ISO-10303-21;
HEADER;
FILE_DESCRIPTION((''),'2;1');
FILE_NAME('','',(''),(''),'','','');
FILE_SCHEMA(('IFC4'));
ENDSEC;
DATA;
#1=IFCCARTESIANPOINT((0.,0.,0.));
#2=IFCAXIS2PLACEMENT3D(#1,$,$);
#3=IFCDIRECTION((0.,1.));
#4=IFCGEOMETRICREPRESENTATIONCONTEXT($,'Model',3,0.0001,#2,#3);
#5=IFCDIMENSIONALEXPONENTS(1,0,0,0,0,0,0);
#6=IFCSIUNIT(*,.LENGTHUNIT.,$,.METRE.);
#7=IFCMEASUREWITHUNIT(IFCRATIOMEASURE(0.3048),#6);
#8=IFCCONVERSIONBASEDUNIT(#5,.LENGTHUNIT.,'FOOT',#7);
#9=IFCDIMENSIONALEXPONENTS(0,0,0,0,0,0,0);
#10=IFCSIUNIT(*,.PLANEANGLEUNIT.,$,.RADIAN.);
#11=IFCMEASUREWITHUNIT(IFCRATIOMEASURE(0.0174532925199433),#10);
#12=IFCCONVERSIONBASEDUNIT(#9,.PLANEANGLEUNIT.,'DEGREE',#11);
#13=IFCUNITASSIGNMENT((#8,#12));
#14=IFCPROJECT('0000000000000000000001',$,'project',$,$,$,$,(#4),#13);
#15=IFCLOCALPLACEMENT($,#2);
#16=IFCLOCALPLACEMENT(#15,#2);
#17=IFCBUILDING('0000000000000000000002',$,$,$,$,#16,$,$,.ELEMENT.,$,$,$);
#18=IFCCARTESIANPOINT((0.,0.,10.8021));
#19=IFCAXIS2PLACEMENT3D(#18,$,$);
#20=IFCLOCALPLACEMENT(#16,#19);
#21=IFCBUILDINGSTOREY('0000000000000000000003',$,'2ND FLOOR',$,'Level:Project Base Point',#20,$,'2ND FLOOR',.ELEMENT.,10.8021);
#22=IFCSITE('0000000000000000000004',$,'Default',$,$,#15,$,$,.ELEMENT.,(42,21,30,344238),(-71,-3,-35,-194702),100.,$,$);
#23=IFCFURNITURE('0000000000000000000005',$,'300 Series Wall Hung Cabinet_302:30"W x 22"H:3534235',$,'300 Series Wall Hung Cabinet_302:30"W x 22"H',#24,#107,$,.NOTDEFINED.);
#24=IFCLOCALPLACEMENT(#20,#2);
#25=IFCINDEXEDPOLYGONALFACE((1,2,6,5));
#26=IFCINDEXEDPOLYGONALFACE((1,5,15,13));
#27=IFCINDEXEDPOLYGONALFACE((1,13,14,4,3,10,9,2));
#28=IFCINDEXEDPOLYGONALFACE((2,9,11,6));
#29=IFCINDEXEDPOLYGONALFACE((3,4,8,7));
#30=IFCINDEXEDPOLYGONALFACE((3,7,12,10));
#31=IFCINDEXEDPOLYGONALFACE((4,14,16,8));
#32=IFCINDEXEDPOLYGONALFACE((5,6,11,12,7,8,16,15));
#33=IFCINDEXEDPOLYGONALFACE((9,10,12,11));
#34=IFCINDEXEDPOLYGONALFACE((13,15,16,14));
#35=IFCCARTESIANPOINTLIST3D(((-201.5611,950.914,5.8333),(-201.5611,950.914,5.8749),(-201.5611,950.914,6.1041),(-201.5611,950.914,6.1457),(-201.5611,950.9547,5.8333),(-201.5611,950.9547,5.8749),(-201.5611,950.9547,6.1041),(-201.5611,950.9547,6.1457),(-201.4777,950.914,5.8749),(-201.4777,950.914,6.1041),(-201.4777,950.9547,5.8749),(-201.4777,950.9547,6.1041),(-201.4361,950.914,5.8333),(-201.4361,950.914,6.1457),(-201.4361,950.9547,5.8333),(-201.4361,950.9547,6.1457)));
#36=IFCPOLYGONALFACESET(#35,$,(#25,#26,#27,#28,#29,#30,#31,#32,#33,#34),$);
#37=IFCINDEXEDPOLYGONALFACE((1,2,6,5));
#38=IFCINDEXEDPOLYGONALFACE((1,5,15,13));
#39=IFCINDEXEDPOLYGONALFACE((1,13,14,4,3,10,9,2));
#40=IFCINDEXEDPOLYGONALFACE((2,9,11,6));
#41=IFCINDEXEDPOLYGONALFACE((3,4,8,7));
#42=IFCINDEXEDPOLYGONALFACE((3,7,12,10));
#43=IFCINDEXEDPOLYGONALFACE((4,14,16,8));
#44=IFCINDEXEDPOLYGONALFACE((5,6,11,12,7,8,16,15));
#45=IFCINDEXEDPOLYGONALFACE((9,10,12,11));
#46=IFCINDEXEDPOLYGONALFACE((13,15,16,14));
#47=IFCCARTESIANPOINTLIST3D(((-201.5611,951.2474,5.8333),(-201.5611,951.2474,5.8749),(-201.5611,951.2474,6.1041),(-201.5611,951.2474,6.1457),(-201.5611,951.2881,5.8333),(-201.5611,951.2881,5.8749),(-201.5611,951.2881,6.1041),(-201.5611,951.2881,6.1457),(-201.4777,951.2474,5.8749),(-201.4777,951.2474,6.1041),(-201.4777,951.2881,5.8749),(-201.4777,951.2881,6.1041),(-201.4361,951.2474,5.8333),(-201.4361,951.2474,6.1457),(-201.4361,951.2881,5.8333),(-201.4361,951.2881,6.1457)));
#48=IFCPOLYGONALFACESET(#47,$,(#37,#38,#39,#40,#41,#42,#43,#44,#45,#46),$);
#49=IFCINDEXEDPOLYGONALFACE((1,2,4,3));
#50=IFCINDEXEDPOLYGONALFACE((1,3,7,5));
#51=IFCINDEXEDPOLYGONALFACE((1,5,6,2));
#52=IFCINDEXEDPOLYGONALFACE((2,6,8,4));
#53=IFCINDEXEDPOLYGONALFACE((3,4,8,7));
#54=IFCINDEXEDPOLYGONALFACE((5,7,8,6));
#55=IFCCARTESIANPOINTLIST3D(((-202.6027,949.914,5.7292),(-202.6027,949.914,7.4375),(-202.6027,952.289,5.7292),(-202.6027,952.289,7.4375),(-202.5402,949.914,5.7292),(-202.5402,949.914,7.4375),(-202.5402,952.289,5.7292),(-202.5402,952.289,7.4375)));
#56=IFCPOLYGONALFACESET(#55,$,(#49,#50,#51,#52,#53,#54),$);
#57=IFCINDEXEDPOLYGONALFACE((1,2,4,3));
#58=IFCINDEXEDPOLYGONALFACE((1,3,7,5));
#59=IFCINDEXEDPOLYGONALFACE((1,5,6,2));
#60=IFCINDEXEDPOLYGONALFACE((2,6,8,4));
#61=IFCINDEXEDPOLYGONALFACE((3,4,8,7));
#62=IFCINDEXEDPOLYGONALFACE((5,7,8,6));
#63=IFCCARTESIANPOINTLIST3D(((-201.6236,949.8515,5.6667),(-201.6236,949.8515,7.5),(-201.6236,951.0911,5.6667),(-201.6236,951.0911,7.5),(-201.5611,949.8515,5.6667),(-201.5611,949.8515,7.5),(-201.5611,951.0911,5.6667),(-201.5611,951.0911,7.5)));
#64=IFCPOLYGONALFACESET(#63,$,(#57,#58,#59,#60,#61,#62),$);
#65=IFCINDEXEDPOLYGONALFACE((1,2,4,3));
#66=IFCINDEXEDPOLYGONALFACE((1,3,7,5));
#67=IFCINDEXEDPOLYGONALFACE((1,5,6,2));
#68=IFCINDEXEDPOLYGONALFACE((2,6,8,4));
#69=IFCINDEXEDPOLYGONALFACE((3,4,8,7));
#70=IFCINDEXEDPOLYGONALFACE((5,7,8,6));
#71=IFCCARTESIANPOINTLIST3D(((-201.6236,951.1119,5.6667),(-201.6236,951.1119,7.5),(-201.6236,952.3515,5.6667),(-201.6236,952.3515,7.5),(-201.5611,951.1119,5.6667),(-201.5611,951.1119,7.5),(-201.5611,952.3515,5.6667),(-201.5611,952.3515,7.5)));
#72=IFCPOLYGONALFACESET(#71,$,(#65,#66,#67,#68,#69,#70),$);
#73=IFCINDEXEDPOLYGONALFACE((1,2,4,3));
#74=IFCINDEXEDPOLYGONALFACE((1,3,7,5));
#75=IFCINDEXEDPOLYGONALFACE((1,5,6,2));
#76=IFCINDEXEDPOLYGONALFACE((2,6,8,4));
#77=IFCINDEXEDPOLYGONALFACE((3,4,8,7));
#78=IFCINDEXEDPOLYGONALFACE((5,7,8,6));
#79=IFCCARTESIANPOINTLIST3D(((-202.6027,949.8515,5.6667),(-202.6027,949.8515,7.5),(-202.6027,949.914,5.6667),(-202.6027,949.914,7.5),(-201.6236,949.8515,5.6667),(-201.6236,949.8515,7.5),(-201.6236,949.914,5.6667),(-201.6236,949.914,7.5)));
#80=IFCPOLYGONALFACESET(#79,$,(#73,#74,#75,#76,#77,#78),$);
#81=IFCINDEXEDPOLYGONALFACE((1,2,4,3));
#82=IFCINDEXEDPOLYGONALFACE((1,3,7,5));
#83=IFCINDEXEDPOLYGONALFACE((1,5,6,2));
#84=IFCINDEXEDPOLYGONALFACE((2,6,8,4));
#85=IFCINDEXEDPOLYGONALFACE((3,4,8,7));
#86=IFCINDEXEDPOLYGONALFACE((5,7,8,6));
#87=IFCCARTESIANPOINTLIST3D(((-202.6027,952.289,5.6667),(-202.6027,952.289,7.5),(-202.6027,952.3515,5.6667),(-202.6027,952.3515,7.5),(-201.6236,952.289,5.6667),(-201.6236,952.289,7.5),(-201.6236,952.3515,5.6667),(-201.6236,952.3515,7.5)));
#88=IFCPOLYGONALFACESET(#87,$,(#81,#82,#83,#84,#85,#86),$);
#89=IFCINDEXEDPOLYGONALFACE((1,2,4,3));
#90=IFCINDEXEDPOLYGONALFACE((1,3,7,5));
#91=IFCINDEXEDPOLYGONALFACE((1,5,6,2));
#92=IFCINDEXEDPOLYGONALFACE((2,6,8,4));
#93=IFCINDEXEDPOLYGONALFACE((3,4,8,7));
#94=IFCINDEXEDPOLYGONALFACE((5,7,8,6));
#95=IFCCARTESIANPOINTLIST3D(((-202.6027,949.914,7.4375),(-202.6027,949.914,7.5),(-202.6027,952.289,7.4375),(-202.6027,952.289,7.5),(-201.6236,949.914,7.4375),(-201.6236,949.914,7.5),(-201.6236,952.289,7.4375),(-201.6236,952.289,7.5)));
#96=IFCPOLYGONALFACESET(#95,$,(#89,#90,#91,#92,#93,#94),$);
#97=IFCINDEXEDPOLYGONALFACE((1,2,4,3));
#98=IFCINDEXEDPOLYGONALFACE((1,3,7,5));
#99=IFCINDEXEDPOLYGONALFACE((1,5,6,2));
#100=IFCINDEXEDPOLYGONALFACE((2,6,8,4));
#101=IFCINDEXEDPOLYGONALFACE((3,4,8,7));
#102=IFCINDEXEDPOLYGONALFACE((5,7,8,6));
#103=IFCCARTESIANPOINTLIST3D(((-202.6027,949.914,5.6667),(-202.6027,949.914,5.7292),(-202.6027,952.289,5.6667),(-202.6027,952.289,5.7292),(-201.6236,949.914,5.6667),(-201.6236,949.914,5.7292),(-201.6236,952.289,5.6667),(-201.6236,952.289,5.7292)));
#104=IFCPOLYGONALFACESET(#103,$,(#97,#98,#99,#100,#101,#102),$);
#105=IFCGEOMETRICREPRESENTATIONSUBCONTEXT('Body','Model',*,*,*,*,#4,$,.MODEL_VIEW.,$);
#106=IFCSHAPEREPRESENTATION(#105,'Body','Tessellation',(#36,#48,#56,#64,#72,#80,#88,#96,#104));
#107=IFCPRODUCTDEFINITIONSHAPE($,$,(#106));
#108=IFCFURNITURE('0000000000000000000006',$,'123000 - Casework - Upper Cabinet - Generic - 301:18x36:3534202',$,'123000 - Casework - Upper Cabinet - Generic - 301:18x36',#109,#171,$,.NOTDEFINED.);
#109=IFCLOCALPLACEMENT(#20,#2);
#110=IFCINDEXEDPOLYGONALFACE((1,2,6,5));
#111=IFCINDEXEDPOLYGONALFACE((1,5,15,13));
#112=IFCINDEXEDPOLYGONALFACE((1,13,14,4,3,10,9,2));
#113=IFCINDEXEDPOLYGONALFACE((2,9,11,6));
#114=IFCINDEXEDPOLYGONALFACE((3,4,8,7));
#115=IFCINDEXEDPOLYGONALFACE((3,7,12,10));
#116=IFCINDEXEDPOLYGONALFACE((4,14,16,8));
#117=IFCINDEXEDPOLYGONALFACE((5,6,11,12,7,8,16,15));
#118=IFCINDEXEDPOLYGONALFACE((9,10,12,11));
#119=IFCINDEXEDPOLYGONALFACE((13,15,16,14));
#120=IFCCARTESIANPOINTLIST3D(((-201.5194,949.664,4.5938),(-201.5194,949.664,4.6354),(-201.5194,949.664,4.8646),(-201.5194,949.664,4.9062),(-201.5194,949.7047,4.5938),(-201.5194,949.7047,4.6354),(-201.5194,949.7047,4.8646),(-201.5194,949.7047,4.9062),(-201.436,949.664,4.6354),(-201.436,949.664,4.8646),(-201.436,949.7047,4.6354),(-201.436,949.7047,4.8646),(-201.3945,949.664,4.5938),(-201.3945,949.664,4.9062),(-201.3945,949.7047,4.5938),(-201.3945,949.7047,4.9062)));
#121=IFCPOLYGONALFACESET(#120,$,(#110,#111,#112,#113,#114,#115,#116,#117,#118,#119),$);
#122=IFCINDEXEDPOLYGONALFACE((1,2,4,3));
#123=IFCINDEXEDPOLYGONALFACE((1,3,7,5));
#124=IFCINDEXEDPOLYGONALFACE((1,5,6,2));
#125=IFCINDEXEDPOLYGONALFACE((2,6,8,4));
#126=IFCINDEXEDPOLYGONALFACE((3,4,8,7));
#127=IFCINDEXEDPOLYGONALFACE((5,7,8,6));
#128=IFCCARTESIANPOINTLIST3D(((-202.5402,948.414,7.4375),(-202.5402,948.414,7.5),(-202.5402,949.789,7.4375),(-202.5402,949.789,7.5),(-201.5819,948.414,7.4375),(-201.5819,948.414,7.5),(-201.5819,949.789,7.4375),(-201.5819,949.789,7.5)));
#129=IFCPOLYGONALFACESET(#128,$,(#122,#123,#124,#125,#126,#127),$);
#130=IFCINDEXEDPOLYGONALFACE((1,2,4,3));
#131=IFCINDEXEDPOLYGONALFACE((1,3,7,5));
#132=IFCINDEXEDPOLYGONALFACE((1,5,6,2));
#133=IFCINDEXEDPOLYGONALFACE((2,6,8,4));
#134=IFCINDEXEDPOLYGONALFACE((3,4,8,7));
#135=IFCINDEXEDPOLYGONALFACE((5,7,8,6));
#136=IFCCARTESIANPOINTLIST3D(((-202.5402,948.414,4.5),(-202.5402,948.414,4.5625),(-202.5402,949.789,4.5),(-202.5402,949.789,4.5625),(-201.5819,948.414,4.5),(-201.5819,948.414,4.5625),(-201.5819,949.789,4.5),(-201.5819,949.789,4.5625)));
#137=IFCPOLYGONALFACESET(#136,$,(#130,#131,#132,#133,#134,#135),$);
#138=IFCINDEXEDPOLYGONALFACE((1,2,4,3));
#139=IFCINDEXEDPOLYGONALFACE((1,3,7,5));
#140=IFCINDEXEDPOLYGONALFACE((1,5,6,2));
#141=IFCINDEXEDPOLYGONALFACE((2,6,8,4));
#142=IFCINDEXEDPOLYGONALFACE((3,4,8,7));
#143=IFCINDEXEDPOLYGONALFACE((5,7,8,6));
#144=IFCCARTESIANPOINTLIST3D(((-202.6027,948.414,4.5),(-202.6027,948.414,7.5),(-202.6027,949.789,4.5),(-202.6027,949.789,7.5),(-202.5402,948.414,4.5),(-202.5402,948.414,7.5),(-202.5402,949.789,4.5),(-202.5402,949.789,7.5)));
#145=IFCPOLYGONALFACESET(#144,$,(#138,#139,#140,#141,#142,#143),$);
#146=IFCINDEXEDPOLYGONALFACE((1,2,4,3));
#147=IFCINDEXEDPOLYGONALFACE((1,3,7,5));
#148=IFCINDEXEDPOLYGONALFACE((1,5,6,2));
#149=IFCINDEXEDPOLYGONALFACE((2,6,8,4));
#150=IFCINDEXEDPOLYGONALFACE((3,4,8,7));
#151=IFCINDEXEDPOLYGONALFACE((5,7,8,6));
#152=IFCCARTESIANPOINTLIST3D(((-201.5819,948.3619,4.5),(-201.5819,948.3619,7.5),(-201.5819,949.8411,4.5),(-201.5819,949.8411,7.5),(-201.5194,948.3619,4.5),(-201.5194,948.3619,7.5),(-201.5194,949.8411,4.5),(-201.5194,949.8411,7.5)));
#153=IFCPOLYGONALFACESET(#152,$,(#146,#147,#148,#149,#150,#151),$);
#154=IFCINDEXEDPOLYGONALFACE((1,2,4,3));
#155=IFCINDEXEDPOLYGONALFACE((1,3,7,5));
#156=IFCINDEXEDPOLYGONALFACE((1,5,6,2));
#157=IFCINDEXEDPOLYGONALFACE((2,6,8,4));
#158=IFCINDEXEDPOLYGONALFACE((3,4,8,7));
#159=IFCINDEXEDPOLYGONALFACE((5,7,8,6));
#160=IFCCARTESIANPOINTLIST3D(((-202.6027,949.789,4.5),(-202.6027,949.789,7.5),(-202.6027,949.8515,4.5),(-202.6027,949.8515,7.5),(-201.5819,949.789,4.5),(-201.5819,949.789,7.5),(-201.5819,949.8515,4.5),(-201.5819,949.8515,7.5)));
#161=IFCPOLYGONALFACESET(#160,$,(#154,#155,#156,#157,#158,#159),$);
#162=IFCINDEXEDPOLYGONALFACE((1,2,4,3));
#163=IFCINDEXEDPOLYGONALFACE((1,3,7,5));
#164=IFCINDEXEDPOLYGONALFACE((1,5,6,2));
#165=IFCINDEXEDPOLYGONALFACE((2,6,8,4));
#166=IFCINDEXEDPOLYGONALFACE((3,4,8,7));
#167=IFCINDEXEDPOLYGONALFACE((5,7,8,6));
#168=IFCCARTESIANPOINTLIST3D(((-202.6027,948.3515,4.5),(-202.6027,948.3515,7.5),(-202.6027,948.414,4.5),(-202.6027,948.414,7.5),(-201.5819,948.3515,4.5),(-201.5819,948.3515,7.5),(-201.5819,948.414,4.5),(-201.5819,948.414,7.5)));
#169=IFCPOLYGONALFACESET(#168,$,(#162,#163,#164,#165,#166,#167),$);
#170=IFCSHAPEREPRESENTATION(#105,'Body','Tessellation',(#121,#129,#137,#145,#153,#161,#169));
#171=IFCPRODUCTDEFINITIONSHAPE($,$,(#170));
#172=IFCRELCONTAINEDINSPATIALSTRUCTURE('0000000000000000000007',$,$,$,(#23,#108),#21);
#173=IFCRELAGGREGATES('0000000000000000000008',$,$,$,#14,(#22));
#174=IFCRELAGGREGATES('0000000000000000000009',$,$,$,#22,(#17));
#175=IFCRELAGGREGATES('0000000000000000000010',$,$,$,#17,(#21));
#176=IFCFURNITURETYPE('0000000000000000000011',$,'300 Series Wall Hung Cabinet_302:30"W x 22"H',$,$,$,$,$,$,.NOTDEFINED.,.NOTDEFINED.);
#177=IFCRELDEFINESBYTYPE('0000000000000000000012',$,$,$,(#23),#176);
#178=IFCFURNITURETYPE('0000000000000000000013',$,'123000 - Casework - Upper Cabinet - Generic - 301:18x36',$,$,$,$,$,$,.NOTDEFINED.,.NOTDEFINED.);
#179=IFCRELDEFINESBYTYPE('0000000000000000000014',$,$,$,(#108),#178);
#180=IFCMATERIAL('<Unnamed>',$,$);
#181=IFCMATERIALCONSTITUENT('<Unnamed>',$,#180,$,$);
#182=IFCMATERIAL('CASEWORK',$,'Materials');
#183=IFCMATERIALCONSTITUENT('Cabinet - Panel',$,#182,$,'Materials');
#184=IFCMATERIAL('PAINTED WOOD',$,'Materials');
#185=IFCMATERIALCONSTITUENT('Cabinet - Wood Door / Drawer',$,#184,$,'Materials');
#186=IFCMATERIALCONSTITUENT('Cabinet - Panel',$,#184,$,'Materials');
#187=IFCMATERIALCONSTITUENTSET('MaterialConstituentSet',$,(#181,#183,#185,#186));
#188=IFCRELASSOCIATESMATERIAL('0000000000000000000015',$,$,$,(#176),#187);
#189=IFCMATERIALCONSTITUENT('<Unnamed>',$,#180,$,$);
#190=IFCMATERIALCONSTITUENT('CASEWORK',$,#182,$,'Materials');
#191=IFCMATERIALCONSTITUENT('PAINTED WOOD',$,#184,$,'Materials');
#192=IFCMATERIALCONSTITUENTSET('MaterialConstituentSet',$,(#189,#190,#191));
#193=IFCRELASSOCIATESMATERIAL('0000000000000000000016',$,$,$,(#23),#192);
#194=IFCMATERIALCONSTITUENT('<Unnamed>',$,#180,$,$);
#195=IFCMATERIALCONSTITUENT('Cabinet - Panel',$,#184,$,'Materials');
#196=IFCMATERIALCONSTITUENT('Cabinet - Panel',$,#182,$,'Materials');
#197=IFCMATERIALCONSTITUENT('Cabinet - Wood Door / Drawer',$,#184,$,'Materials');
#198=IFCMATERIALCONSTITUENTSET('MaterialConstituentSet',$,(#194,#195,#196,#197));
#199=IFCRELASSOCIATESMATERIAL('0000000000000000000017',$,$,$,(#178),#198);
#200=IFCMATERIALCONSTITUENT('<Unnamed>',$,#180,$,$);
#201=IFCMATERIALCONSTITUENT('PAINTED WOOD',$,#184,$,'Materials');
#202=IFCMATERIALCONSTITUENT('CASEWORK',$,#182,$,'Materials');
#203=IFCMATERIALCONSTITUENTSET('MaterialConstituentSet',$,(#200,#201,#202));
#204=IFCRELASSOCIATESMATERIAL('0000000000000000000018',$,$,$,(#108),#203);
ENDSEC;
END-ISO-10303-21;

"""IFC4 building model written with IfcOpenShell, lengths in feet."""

from ifc_helpers import new_model, entity, si_unit, converted_unit, direction, frame, frame_2d, origin, origin_2d_with_axis, place, context, subcontext, project, spatial, polyline, rectangle, outline, extrude, source, transform, mapped, material, constituent, constituent_set, type_object, type_shapes, element, save


model = new_model("IFC4")

# Units and contexts
model_context = context("Model", 3, precision=0.0001, world=origin(), true_north=direction((0.0, 1.0)))
body_context = subcontext(model_context, "Body", "Model", "MODEL_VIEW")
ifc_project = project(units=[converted_unit("LENGTHUNIT", "FOOT", entity("IfcRatioMeasure", 0.3048), si_unit("LENGTHUNIT", "METRE"), dimensions=[1, 0, 0, 0, 0, 0, 0]), converted_unit("PLANEANGLEUNIT", "DEGREE", entity("IfcRatioMeasure", 0.0174532925199433), si_unit("PLANEANGLEUNIT", "RADIAN"), dimensions=[0, 0, 0, 0, 0, 0, 0])], contexts=[model_context])

# Site, building, storey
site_placement = place(None, origin())
site = spatial("IfcSite", under=ifc_project, at=site_placement, Name="Default", CompositionType="ELEMENT", RefLatitude=(42, 21, 30, 344238), RefLongitude=(-71, -3, -35, -194702), RefElevation=100.0)
building_placement = place(site_placement, origin())
building = spatial("IfcBuilding", under=site, at=building_placement, CompositionType="ELEMENT")
storey_placement = place(building_placement, frame((0.0, 0.0, 10.8021)))
storey = spatial("IfcBuildingStorey", under=building, at=storey_placement, Name="2ND FLOOR", ObjectType="Level:Project Base Point", LongName="2ND FLOOR", CompositionType="ELEMENT", Elevation=10.8021)

# Furniture
ifc_material_1 = material(Name="CASEWORK", Category="Materials")
ifc_material_2 = material(Name="PAINTED WOOD", Category="Materials")
ifc_material_3 = material(Name="<Unnamed>")
ifc_constituent_1 = constituent(ifc_material_3, Name="<Unnamed>")
ifc_constituent_2 = constituent(ifc_material_1, Name="CASEWORK", Category="Materials")
ifc_constituent_3 = constituent(ifc_material_2, Name="PAINTED WOOD", Category="Materials")
ifc_constituent_set_1 = constituent_set(constituents=[ifc_constituent_1, ifc_constituent_2, ifc_constituent_3], Name="MaterialConstituentSet")
ifc_constituent_4 = constituent(ifc_material_3, Name="<Unnamed>")
ifc_constituent_5 = constituent(ifc_material_1, Name="Cabinet - Panel", Category="Materials")
ifc_constituent_6 = constituent(ifc_material_2, Name="Cabinet - Wood Door / Drawer", Category="Materials")
ifc_constituent_7 = constituent(ifc_material_2, Name="Cabinet - Panel", Category="Materials")
ifc_constituent_set_2 = constituent_set(constituents=[ifc_constituent_4, ifc_constituent_5, ifc_constituent_6, ifc_constituent_7], Name="MaterialConstituentSet")
furniture_type_1 = type_object("IfcFurnitureType", Name="300 Series Wall Hung Cabinet_302:30\"W x 22\"H", AssemblyPlace="NOTDEFINED", PredefinedType="NOTDEFINED", material=ifc_constituent_set_2)
shared_shape_1 = source(origin(), body_context, "Body", "SweptSolid", [
    extrude(outline(polyline([(0.1146, -0.0521), (0.1562, -0.0521), (0.1562, 0.0729), (-0.1562, 0.0729), (-0.1562, -0.0521), (-0.1146, -0.0521), (-0.1146, 0.0313), (0.1146, 0.0313), (0.1146, -0.0521)])), frame((1.0625, 0.0729, 0.3229), z_axis=(1.0, 0.0, 0.0), x_axis=(0.0, 0.0, 1.0)), (0.0, 0.0, 1.0), 0.0407),
    extrude(outline(polyline([(0.1146, -0.0521), (0.1562, -0.0521), (0.1562, 0.0729), (-0.1562, 0.0729), (-0.1562, -0.0521), (-0.1146, -0.0521), (-0.1146, 0.0313), (0.1146, 0.0313), (0.1146, -0.0521)])), frame((1.3958, 0.0729, 0.3229), z_axis=(1.0, 0.0, 0.0), x_axis=(0.0, 0.0, 1.0)), (0.0, 0.0, 1.0), 0.0407),
    extrude(rectangle(XDim=2.375, YDim=0.0625, at=origin_2d_with_axis()), frame((1.25, 1.1354, 0.0625), z_axis=(0.0, 0.0, 1.0), x_axis=(-1.0, 0.0, 0.0)), (0.0, 0.0, 1.0), 1.7083),
    extrude(rectangle(XDim=1.2396, YDim=0.0625, at=origin_2d_with_axis()), frame((0.6198, 0.1562, 0.0), z_axis=(0.0, 0.0, 1.0), x_axis=(-1.0, 0.0, 0.0)), (0.0, 0.0, 1.0), 1.8333),
    extrude(rectangle(XDim=1.2396, YDim=0.0625, at=frame_2d((0.0, 0.0), x_axis=(1.0, 0.0))), frame((1.8802, 0.1562, 0.0), z_axis=(0.0, 0.0, 1.0), x_axis=(-1.0, 0.0, 0.0)), (0.0, 0.0, 1.0), 1.8333),
    extrude(rectangle(XDim=0.9792, YDim=0.0625, at=frame_2d((0.0, 0.0), x_axis=(1.0, 0.0))), frame((0.0313, 0.677, 0.0), z_axis=(0.0, 0.0, 1.0), x_axis=(0.0, -1.0, 0.0)), (0.0, 0.0, 1.0), 1.8333),
    extrude(rectangle(XDim=0.9792, YDim=0.0625, at=frame_2d((0.0, 0.0), x_axis=(1.0, 0.0))), frame((2.4688, 0.677, 0.0), z_axis=(0.0, 0.0, 1.0), x_axis=(0.0, -1.0, 0.0)), (0.0, 0.0, 1.0), 1.8333),
    extrude(rectangle(XDim=0.9792, YDim=2.375, at=frame_2d((0.0, 0.0), x_axis=(1.0, 0.0))), frame((1.25, 0.677, 1.7708), z_axis=(0.0, 0.0, 1.0), x_axis=(0.0, 1.0, 0.0)), (0.0, 0.0, 1.0), 0.0625),
    extrude(rectangle(XDim=0.9792, YDim=2.375, at=frame_2d((0.0, 0.0), x_axis=(1.0, 0.0))), frame((1.25, 0.677, 0.0), z_axis=(0.0, 0.0, 1.0), x_axis=(0.0, 1.0, 0.0)), (0.0, 0.0, 1.0), 0.0625),
])
type_shapes(furniture_type_1, [shared_shape_1])
furniture_1_placement = place(storey_placement, frame((-201.4361, 949.8515, 5.6667), z_axis=(0.0, 0.0, 1.0), x_axis=(0.0, 1.0, 0.0)))
element("IfcFurniture", 1, at=furniture_1_placement, inside=storey, type_object=furniture_type_1, material=ifc_constituent_set_1, Name="300 Series Wall Hung Cabinet_302:30\"W x 22\"H:3534235", ObjectType="300 Series Wall Hung Cabinet_302:30\"W x 22\"H", PredefinedType="NOTDEFINED", context=body_context, shape_type="MappedRepresentation", body=[
    mapped(shared_shape_1, transform((0.0, 0.0, 0.0), scale=1.0)),
])
ifc_constituent_8 = constituent(ifc_material_3, Name="<Unnamed>")
ifc_constituent_9 = constituent(ifc_material_2, Name="PAINTED WOOD", Category="Materials")
ifc_constituent_10 = constituent(ifc_material_1, Name="CASEWORK", Category="Materials")
ifc_constituent_set_3 = constituent_set(constituents=[ifc_constituent_8, ifc_constituent_9, ifc_constituent_10], Name="MaterialConstituentSet")
ifc_constituent_11 = constituent(ifc_material_3, Name="<Unnamed>")
ifc_constituent_12 = constituent(ifc_material_2, Name="Cabinet - Panel", Category="Materials")
ifc_constituent_13 = constituent(ifc_material_1, Name="Cabinet - Panel", Category="Materials")
ifc_constituent_14 = constituent(ifc_material_2, Name="Cabinet - Wood Door / Drawer", Category="Materials")
ifc_constituent_set_4 = constituent_set(constituents=[ifc_constituent_11, ifc_constituent_12, ifc_constituent_13, ifc_constituent_14], Name="MaterialConstituentSet")
furniture_type_2 = type_object("IfcFurnitureType", Name="123000 - Casework - Upper Cabinet - Generic - 301:18x36", AssemblyPlace="NOTDEFINED", PredefinedType="NOTDEFINED", material=ifc_constituent_set_4)
shared_shape_2 = source(origin(), body_context, "Body", "SweptSolid", [
    extrude(outline(polyline([(-0.0521, -0.1146), (-0.0521, -0.1562), (0.0729, -0.1562), (0.0729, 0.1562), (-0.0521, 0.1562), (-0.0521, 0.1146), (0.0313, 0.1146), (0.0313, -0.1146), (-0.0521, -0.1146)])), frame((0.1468, 1.1354, 0.25), z_axis=(-1.0, 0.0, 0.0), x_axis=(0.0, 1.0, 0.0)), (0.0, 0.0, -1.0), 0.0407),
    extrude(rectangle(XDim=0.9583, YDim=1.375, at=frame_2d((0.0, 0.0), x_axis=(1.0, 0.0))), frame((0.75, 0.5417, 2.9375), z_axis=(0.0, 0.0, 1.0), x_axis=(0.0, 1.0, 0.0)), (0.0, 0.0, 1.0), 0.0625),
    extrude(rectangle(XDim=0.9583, YDim=1.375, at=frame_2d((0.0, 0.0), x_axis=(1.0, 0.0))), frame((0.75, 0.5417, 0.0), z_axis=(0.0, 0.0, 1.0), x_axis=(0.0, 1.0, 0.0)), (0.0, 0.0, 1.0), 0.0625),
    extrude(rectangle(XDim=1.375, YDim=0.0625, at=origin_2d_with_axis()), frame((0.75, 0.0313, 0.0), z_axis=(0.0, 0.0, 1.0), x_axis=(-1.0, 0.0, 0.0)), (0.0, 0.0, 1.0), 3.0),
    extrude(rectangle(XDim=1.4792, YDim=0.0625, at=origin_2d_with_axis()), frame((0.75, 1.0521, 0.0)), (0.0, 0.0, 1.0), 3.0),
    extrude(rectangle(XDim=1.0208, YDim=0.0625, at=origin_2d_with_axis()), frame((0.0312, 0.5104, 0.0), z_axis=(0.0, 0.0, 1.0), x_axis=(0.0, 1.0, 0.0)), (0.0, 0.0, 1.0), 3.0),
    extrude(rectangle(XDim=1.0208, YDim=0.0625, at=origin_2d_with_axis()), frame((1.4688, 0.5104, 0.0), z_axis=(0.0, 0.0, 1.0), x_axis=(0.0, 1.0, 0.0)), (0.0, 0.0, 1.0), 3.0),
])
type_shapes(furniture_type_2, [shared_shape_2])
furniture_2_placement = place(storey_placement, frame((-202.6027, 949.8515, 4.5), z_axis=(0.0, 0.0, 1.0), x_axis=(0.0, -1.0, 0.0)))
element("IfcFurniture", 2, at=furniture_2_placement, inside=storey, type_object=furniture_type_2, material=ifc_constituent_set_3, Name="123000 - Casework - Upper Cabinet - Generic - 301:18x36:3534202", ObjectType="123000 - Casework - Upper Cabinet - Generic - 301:18x36", PredefinedType="NOTDEFINED", context=body_context, shape_type="MappedRepresentation", body=[
    mapped(shared_shape_2, transform((0.0, 0.0, 0.0), scale=1.0)),
])

save(model, "model.ifc")
